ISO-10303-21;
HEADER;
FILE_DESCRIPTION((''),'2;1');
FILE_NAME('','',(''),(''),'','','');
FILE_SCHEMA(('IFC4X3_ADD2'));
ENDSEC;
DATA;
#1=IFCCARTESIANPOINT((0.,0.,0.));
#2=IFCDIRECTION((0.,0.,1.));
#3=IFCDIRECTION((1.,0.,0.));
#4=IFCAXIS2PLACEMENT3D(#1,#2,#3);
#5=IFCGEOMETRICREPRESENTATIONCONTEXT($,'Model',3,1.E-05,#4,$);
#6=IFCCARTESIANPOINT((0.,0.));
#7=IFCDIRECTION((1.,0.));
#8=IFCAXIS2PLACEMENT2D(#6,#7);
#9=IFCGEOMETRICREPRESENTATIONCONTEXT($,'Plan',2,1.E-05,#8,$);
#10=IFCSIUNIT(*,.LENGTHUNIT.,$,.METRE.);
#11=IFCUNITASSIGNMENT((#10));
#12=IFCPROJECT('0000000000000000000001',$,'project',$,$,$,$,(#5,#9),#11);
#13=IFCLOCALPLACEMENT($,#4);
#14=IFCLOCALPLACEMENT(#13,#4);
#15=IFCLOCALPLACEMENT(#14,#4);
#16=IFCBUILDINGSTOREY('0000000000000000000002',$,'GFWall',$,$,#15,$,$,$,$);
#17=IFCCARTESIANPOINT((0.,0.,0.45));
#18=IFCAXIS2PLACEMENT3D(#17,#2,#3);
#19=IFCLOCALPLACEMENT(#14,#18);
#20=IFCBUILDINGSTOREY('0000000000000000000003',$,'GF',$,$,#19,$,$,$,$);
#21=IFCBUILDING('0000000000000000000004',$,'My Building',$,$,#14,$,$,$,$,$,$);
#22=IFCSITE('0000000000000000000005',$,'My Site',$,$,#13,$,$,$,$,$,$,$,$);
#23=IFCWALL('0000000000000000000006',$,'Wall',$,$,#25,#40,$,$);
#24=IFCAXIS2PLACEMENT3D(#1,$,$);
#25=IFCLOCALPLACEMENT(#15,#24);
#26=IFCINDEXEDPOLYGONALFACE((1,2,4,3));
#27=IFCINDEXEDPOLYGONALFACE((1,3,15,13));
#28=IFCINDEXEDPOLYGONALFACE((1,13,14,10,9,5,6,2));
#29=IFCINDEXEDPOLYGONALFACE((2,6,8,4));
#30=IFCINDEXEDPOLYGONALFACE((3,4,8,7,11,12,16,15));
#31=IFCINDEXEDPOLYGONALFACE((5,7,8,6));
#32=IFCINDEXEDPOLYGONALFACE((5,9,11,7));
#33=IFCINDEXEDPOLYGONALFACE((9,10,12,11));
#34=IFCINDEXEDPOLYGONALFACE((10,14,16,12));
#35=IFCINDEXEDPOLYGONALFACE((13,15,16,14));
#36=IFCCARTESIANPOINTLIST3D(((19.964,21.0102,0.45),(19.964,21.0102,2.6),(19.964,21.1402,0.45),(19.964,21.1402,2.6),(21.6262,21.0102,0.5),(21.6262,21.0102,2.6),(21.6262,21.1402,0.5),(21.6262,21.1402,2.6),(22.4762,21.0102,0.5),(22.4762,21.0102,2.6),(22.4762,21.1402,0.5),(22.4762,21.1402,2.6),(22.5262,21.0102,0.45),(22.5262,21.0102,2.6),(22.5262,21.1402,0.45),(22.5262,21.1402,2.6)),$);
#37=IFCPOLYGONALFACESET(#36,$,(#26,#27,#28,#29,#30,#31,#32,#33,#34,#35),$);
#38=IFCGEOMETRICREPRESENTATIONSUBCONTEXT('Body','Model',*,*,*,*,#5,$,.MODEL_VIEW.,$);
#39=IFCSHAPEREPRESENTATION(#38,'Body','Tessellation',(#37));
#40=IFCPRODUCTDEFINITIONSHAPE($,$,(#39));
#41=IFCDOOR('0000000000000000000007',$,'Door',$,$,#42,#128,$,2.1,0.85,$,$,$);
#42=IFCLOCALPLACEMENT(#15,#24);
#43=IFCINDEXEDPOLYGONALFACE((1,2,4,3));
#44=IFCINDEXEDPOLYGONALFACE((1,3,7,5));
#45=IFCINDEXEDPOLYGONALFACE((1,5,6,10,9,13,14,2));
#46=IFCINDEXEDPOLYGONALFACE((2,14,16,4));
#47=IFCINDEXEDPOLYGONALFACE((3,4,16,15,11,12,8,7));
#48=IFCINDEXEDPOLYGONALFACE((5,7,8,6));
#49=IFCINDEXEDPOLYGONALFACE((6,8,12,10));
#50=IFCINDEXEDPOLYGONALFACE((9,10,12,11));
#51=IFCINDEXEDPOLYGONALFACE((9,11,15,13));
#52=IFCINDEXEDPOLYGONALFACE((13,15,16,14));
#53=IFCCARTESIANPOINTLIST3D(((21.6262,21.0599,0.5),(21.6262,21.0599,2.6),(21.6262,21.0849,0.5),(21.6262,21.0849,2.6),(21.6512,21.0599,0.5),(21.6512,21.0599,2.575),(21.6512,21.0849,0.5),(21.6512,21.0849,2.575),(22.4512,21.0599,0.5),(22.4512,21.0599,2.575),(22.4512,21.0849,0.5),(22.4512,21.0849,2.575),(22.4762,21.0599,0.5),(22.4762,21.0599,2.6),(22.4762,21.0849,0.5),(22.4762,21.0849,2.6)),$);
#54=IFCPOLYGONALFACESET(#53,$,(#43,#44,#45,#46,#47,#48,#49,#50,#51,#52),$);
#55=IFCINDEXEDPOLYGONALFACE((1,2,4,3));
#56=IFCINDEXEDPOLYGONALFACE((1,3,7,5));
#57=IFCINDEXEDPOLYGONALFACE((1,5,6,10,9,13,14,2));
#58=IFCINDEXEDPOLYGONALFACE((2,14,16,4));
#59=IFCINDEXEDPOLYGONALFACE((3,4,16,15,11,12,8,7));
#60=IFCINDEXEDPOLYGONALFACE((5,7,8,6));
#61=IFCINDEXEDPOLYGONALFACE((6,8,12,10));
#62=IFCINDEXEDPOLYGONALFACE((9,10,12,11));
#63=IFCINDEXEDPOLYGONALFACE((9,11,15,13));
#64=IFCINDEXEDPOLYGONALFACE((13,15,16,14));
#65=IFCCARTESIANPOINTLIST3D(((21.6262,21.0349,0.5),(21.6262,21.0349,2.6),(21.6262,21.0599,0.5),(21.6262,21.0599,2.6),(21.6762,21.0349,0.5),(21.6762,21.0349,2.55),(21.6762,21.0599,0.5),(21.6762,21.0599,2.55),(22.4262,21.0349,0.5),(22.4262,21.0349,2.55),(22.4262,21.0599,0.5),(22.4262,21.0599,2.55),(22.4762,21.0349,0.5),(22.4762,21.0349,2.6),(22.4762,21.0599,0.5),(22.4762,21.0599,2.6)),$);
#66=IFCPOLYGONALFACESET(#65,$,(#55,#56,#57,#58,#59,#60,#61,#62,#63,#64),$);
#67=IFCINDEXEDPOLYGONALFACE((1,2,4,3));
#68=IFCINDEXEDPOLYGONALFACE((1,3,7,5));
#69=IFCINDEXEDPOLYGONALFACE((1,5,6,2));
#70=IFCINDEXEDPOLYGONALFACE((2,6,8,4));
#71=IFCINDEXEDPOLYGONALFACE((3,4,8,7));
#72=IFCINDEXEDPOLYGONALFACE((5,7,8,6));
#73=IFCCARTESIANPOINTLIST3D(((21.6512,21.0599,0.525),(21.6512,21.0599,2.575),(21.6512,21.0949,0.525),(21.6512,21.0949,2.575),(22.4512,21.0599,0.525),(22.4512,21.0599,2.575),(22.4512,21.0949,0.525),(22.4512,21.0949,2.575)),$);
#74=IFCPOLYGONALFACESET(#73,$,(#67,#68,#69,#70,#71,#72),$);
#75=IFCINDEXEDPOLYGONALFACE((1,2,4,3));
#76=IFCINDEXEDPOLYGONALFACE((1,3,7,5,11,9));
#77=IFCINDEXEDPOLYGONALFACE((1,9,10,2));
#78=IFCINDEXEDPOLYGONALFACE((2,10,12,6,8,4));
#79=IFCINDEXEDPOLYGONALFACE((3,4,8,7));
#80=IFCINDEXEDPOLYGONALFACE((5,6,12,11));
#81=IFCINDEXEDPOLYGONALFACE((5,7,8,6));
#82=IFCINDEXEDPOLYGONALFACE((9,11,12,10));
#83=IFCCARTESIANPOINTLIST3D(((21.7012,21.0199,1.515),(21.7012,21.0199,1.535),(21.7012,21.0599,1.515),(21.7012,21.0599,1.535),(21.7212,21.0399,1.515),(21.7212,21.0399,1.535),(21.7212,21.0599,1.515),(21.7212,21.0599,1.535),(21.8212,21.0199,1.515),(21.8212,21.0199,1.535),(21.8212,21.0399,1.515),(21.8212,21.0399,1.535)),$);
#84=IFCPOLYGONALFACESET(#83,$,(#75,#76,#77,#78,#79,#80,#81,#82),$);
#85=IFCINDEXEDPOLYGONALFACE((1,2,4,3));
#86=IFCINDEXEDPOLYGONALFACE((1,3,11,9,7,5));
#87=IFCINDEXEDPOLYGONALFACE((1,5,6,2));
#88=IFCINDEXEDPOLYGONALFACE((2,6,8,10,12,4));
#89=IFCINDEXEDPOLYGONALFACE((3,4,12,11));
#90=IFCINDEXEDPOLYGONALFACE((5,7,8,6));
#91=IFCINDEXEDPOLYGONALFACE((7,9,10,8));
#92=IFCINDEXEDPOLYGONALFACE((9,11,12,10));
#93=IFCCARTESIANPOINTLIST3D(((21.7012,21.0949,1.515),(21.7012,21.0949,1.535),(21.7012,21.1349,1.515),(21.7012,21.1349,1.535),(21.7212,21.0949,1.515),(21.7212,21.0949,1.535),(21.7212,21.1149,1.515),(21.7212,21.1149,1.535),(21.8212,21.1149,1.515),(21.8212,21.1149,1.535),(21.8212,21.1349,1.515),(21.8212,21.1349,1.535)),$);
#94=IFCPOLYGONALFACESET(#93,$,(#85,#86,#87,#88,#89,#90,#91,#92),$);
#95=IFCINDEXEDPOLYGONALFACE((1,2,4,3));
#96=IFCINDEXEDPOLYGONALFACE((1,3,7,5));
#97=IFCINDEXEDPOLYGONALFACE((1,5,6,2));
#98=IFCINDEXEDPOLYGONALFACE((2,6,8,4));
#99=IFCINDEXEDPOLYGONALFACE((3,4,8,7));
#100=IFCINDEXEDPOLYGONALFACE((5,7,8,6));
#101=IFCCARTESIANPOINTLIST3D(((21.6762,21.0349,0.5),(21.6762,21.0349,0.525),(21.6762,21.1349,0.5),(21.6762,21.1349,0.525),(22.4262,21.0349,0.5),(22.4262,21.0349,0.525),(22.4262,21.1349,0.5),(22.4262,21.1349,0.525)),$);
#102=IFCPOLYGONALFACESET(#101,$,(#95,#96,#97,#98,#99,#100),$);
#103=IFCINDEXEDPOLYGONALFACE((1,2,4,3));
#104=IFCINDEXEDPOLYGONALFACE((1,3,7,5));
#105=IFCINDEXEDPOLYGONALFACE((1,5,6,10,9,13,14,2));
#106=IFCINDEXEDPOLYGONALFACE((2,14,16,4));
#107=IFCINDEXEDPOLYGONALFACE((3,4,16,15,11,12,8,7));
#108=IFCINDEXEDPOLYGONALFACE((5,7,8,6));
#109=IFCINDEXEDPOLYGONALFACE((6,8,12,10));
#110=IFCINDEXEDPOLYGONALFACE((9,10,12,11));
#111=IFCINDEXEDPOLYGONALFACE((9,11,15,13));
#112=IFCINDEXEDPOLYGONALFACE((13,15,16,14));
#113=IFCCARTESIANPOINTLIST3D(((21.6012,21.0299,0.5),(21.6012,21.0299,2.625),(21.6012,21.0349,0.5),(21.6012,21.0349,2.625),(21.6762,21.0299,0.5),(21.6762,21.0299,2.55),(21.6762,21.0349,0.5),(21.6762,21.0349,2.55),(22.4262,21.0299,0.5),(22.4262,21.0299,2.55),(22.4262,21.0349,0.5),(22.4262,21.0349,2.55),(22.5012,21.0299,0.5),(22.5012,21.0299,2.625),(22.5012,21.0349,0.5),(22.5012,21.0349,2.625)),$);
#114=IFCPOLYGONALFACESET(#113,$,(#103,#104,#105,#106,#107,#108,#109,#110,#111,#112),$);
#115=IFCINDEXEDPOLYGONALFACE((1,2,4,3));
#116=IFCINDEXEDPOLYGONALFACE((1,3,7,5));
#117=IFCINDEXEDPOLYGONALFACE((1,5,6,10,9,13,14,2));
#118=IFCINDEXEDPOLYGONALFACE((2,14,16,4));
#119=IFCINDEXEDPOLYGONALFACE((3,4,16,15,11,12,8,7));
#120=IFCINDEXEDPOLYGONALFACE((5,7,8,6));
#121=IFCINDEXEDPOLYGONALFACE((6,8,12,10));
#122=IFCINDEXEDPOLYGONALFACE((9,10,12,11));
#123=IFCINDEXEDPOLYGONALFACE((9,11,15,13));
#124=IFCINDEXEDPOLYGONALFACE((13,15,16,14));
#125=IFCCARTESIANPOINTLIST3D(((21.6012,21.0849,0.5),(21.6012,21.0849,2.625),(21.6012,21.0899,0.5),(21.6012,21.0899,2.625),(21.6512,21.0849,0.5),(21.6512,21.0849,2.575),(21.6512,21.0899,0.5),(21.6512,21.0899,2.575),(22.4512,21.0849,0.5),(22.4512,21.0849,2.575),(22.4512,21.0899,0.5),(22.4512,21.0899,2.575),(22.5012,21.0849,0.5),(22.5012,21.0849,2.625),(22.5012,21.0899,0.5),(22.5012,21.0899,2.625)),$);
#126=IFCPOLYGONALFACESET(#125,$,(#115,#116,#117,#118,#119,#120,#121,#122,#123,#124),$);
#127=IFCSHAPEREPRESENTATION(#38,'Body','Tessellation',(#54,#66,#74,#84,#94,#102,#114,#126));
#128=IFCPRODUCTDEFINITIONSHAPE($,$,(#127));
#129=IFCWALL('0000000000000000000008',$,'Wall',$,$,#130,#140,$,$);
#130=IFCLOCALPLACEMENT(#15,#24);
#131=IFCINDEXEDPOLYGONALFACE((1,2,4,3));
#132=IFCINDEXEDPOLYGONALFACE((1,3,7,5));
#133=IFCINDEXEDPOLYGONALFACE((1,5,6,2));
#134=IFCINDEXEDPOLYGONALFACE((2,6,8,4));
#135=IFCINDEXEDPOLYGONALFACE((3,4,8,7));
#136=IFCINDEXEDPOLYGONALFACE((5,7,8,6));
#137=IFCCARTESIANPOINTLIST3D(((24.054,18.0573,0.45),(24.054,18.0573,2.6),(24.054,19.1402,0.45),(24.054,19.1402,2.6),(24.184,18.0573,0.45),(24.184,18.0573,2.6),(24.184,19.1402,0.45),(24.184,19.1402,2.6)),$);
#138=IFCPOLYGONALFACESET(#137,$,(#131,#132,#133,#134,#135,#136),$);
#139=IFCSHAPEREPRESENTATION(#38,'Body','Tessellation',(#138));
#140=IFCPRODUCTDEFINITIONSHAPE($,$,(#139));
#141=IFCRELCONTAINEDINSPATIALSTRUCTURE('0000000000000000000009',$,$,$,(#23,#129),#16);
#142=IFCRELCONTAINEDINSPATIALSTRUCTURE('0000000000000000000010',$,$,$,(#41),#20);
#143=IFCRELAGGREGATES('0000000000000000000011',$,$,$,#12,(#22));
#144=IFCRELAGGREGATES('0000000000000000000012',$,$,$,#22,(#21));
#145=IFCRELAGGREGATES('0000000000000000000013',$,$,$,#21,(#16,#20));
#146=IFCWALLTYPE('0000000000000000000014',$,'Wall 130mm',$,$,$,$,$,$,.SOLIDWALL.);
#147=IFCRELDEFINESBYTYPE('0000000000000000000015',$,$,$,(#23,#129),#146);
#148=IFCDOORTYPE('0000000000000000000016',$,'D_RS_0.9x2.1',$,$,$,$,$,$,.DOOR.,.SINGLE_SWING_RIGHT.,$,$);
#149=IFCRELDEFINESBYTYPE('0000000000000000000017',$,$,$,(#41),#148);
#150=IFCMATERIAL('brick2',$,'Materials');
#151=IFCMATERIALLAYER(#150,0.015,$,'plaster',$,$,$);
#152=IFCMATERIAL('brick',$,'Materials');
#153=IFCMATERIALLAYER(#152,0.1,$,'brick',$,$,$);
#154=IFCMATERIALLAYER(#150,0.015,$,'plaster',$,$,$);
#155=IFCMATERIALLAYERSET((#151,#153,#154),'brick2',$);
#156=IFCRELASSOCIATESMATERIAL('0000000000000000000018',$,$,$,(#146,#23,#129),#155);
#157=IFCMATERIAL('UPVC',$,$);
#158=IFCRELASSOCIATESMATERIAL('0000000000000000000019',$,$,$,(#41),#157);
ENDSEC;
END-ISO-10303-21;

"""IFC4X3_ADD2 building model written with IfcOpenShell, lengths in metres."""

from ifc_helpers import new_model, entity, si_unit, frame, origin_with_axes, origin_2d_with_axis, place, context, subcontext, project, spatial, line, indexed_curve, outline, extrude, shape, source, transform, mapped, material, layer, layer_set, layer_usage, type_object, type_shapes, element, fill, save


model = new_model("IFC4X3_ADD2")

# Units and contexts
model_context = context("Model", 3, precision=1e-05, world=origin_with_axes())
plan_context = context("Plan", 2, precision=1e-05, world=origin_2d_with_axis())
body_context_1 = subcontext(model_context, "Body", "Model", "MODEL_VIEW")
body_context_2 = subcontext(plan_context, "Body", "Plan", "PLAN_VIEW")
ifc_project = project(units=[si_unit("LENGTHUNIT", "METRE")], contexts=[model_context, plan_context])

# Site, building, storey
site_placement = place(None, origin_with_axes())
site = spatial("IfcSite", under=ifc_project, at=site_placement, Name="My Site")
building_placement = place(site_placement, origin_with_axes())
building = spatial("IfcBuilding", under=site, at=building_placement, Name="My Building")
storey_1_placement = place(building_placement, origin_with_axes())
storey_1 = spatial("IfcBuildingStorey", under=building, at=storey_1_placement, Name="GFWall")

# Shared definitions
ifc_material_1 = material(Name="brick2", Category="Materials")
ifc_material_2 = material(Name="brick", Category="Materials")

# Shared definitions
storey_2_placement = place(building_placement, frame((0.0, 0.0, 0.45), z_axis=(0.0, 0.0, 1.0), x_axis=(1.0, 0.0, 0.0)))
storey_2 = spatial("IfcBuildingStorey", under=building, at=storey_2_placement, Name="GF")

# Shared definitions
ifc_material_3 = material(Name="UPVC")

# Wall, opening, door
ifc_layer_1 = layer(ifc_material_1, 0.015, Name="plaster")
ifc_layer_2 = layer(ifc_material_2, 0.1, Name="brick")
ifc_layer_3 = layer(ifc_material_1, 0.015, Name="plaster")
ifc_layer_set_1 = layer_set([ifc_layer_1, ifc_layer_2, ifc_layer_3], Name="brick2")
ifc_layer_usage_1 = layer_usage(ifc_layer_set_1, "AXIS2", "POSITIVE", 0.0)
wall_type_1 = type_object("IfcWallType", Name="Wall 130mm", PredefinedType="SOLIDWALL", material=ifc_layer_set_1)
wall_1_placement = place(storey_1_placement, frame((22.6562, 21.1402, 0.45), z_axis=(0.0, 0.0, 1.0), x_axis=(-1.0, 0.0, 0.0)))
wall_1 = element("IfcWall", 1, at=wall_1_placement, inside=storey_1, type_object=wall_type_1, material=ifc_layer_usage_1, Name="Wall", context=body_context_1, shape_type="SweptSolid", body=[
    extrude(outline(indexed_curve([(0.13, 0.0), (0.13, 0.13), (2.6922, 0.13), (2.6922, 0.0)], segments=[line(1, 2, 3, 4, 1)])), origin_with_axes(), (0.0, 0.0, 1.0), 2.15),
])
shared_shape_1 = source(origin_with_axes(), body_context_1, "Body", "SweptSolid", [
    extrude(outline(indexed_curve([(0.0, 0.0), (0.85, 0.0), (0.85, 2.1), (0.0, 2.1)], segments=[line(1, 2, 3, 4, 1)])), frame((0.0, -0.6, 0.0), z_axis=(0.0, -1.0, 0.0), x_axis=(1.0, 0.0, 0.0)), (0.0, 0.0, -1.0), 1.2),
])
opening_1_placement = place(wall_1_placement, frame((1.03, 0.1053, 0.05), z_axis=(0.0, 0.0, 1.0), x_axis=(-1.0, 0.0, 0.0)))
opening_1 = element("IfcOpeningElement", 2, at=opening_1_placement, cuts=wall_1, PredefinedType="OPENING", context=body_context_1, shape_type="MappedRepresentation", body=[
    mapped(shared_shape_1, transform((0.0, 0.0, 0.0), x_axis=(1.0, 0.0, 0.0), y_axis=(0.0, 1.0, 0.0), z_axis=(0.0, 0.0, 1.0), scale=1.0)),
])
door_type_1 = type_object("IfcDoorType", Name="D_RS_0.9x2.1", OperationType="SINGLE_SWING_RIGHT", PredefinedType="DOOR")
shared_shape_2 = source(origin_with_axes(), body_context_1, "Body", "SweptSolid", [
    extrude(outline(indexed_curve([(0.0, 0.0), (0.0, 2.1), (0.85, 2.1), (0.85, 0.0), (0.825, 0.0), (0.825, 2.075), (0.025, 2.075), (0.025, 0.0)], segments=[line(1, 2, 3, 4, 5, 6, 7, 8, 1)])), frame((0.0, 0.025, 0.0), z_axis=(0.0, -1.0, 0.0), x_axis=(1.0, 0.0, 0.0)), (0.0, 0.0, -1.0), 0.025),
    extrude(outline(indexed_curve([(0.0, 0.0), (0.0, 2.1), (0.85, 2.1), (0.85, 0.0), (0.8, 0.0), (0.8, 2.05), (0.05, 2.05), (0.05, 0.0)], segments=[line(1, 2, 3, 4, 5, 6, 7, 8, 1)])), frame((0.0, 0.0, 0.0), z_axis=(0.0, -1.0, 0.0), x_axis=(1.0, 0.0, 0.0)), (0.0, 0.0, -1.0), 0.025),
    extrude(outline(indexed_curve([(0.0, 0.0), (0.8, 0.0), (0.8, 0.035), (0.0, 0.035)], segments=[line(1, 2, 3, 4, 1)])), frame((0.025, 0.025, 0.025), z_axis=(0.0, 0.0, 1.0), x_axis=(1.0, 0.0, 0.0)), (0.0, 0.0, 1.0), 2.05),
    extrude(outline(indexed_curve([(0.0, 0.0), (0.0, -0.04), (0.12, -0.04), (0.12, -0.02), (0.02, -0.02), (0.02, 0.0)], segments=[line(1, 2, 3, 4, 5, 6, 1)])), frame((0.075, 0.025, 1.015), z_axis=(0.0, 0.0, 1.0), x_axis=(1.0, 0.0, 0.0)), (0.0, 0.0, 1.0), 0.02),
    extrude(outline(indexed_curve([(0.0, 0.0), (0.0, 0.04), (0.12, 0.04), (0.12, 0.02), (0.02, 0.02), (0.02, 0.0)], segments=[line(1, 2, 3, 4, 5, 6, 1)])), frame((0.075, 0.06, 1.015), z_axis=(0.0, 0.0, 1.0), x_axis=(1.0, 0.0, 0.0)), (0.0, 0.0, 1.0), 0.02),
    extrude(outline(indexed_curve([(0.0, 0.0), (0.75, 0.0), (0.75, 0.1), (0.0, 0.1)], segments=[line(1, 2, 3, 4, 1)])), frame((0.05, 0.0, 0.0), z_axis=(0.0, 0.0, 1.0), x_axis=(1.0, 0.0, 0.0)), (0.0, 0.0, 1.0), 0.025),
    extrude(outline(indexed_curve([(0.0, 0.0), (0.0, 2.125), (0.9, 2.125), (0.9, 0.0), (0.825, 0.0), (0.825, 2.05), (0.075, 2.05), (0.075, 0.0)], segments=[line(1, 2, 3, 4, 5, 6, 7, 8, 1)])), frame((-0.025, -0.005, 0.0), z_axis=(0.0, -1.0, 0.0), x_axis=(1.0, 0.0, 0.0)), (0.0, 0.0, -1.0), 0.005),
    extrude(outline(indexed_curve([(0.0, 0.0), (0.0, 2.125), (0.9, 2.125), (0.9, 0.0), (0.85, 0.0), (0.85, 2.075), (0.05, 2.075), (0.05, 0.0)], segments=[line(1, 2, 3, 4, 5, 6, 7, 8, 1)])), frame((-0.025, 0.05, 0.0), z_axis=(0.0, -1.0, 0.0), x_axis=(1.0, 0.0, 0.0)), (0.0, 0.0, -1.0), 0.005),
])
shared_shape_3 = source(origin_with_axes(), body_context_2, "Body", "Curve2D", [
    entity("IfcIndexedPolyCurve", entity("IfcCartesianPointList2D", [[0.0, 0.0], [0.0, 0.05], [0.025, 0.05], [0.025, 0.025], [0.05, 0.025], [0.05, 0.0]]), [entity("IfcLineIndex", [1, 2, 3, 4, 5, 6, 1])]),
    entity("IfcIndexedPolyCurve", entity("IfcCartesianPointList2D", [[0.85, 0.0], [0.85, 0.05], [0.825, 0.05], [0.825, 0.025], [0.8, 0.025], [0.8, 0.0]]), [entity("IfcLineIndex", [1, 2, 3, 4, 5, 6, 1])]),
    entity("IfcTrimmedCurve", entity("IfcEllipse", entity("IfcAxis2Placement2D", entity("IfcCartesianPoint", [0.79, 0.05]), entity("IfcDirection", [1.0, 0.0])), 0.765, 0.8), [entity("IfcCartesianPoint", [0.79, 0.85])], [entity("IfcCartesianPoint", [0.025, 0.05])], True, "CARTESIAN"),
    entity("IfcIndexedPolyCurve", entity("IfcCartesianPointList2D", [[0.825, 0.05], [0.79, 0.05], [0.79, 0.85], [0.825, 0.85]]), [entity("IfcLineIndex", [1, 2, 3, 4, 1])]),
])
type_shapes(door_type_1, [shared_shape_2, shared_shape_3])
door_1_placement = place(opening_1_placement, frame((0.0, 0.0, 0.0), z_axis=(0.0, 0.0, 1.0), x_axis=(1.0, 0.0, 0.0)))
door_1 = element("IfcDoor", 3, at=door_1_placement, inside=storey_2, type_object=door_type_1, material=ifc_material_3, Name="Door", OverallHeight=2.1, OverallWidth=0.85, shapes=[
    shape(body_context_1, "Body", "MappedRepresentation", [mapped(shared_shape_2, transform((0.0, 0.0, 0.0), x_axis=(1.0, 0.0, 0.0), y_axis=(0.0, 1.0, 0.0), z_axis=(0.0, 0.0, 1.0), scale=1.0))]),
    shape(body_context_2, "Body", "MappedRepresentation", [mapped(shared_shape_3, transform((0.0, 0.0, 0.0), x_axis=(1.0, 0.0, 0.0), y_axis=(0.0, 1.0, 0.0), z_axis=(0.0, 0.0, 1.0), scale=1.0))]),
])
fill(opening_1, door_1)

# Wall
ifc_layer_usage_2 = layer_usage(ifc_layer_set_1, "AXIS2", "POSITIVE", 0.0)
wall_2_placement = place(storey_1_placement, frame((24.184, 18.0573, 0.45), z_axis=(0.0, 0.0, 1.0), x_axis=(0.000001, 1.0, 0.0)))
element("IfcWall", 4, at=wall_2_placement, inside=storey_1, type_object=wall_type_1, material=ifc_layer_usage_2, Name="Wall", context=body_context_1, shape_type="SweptSolid", body=[
    extrude(outline(indexed_curve([(0.0, 0.0), (0.0, 0.13), (1.0829, 0.13), (1.0829, 0.0)], segments=[line(1, 2, 3, 4, 1)])), origin_with_axes(), (0.0, 0.0, 1.0), 2.15),
])

save(model, "model.ifc")
